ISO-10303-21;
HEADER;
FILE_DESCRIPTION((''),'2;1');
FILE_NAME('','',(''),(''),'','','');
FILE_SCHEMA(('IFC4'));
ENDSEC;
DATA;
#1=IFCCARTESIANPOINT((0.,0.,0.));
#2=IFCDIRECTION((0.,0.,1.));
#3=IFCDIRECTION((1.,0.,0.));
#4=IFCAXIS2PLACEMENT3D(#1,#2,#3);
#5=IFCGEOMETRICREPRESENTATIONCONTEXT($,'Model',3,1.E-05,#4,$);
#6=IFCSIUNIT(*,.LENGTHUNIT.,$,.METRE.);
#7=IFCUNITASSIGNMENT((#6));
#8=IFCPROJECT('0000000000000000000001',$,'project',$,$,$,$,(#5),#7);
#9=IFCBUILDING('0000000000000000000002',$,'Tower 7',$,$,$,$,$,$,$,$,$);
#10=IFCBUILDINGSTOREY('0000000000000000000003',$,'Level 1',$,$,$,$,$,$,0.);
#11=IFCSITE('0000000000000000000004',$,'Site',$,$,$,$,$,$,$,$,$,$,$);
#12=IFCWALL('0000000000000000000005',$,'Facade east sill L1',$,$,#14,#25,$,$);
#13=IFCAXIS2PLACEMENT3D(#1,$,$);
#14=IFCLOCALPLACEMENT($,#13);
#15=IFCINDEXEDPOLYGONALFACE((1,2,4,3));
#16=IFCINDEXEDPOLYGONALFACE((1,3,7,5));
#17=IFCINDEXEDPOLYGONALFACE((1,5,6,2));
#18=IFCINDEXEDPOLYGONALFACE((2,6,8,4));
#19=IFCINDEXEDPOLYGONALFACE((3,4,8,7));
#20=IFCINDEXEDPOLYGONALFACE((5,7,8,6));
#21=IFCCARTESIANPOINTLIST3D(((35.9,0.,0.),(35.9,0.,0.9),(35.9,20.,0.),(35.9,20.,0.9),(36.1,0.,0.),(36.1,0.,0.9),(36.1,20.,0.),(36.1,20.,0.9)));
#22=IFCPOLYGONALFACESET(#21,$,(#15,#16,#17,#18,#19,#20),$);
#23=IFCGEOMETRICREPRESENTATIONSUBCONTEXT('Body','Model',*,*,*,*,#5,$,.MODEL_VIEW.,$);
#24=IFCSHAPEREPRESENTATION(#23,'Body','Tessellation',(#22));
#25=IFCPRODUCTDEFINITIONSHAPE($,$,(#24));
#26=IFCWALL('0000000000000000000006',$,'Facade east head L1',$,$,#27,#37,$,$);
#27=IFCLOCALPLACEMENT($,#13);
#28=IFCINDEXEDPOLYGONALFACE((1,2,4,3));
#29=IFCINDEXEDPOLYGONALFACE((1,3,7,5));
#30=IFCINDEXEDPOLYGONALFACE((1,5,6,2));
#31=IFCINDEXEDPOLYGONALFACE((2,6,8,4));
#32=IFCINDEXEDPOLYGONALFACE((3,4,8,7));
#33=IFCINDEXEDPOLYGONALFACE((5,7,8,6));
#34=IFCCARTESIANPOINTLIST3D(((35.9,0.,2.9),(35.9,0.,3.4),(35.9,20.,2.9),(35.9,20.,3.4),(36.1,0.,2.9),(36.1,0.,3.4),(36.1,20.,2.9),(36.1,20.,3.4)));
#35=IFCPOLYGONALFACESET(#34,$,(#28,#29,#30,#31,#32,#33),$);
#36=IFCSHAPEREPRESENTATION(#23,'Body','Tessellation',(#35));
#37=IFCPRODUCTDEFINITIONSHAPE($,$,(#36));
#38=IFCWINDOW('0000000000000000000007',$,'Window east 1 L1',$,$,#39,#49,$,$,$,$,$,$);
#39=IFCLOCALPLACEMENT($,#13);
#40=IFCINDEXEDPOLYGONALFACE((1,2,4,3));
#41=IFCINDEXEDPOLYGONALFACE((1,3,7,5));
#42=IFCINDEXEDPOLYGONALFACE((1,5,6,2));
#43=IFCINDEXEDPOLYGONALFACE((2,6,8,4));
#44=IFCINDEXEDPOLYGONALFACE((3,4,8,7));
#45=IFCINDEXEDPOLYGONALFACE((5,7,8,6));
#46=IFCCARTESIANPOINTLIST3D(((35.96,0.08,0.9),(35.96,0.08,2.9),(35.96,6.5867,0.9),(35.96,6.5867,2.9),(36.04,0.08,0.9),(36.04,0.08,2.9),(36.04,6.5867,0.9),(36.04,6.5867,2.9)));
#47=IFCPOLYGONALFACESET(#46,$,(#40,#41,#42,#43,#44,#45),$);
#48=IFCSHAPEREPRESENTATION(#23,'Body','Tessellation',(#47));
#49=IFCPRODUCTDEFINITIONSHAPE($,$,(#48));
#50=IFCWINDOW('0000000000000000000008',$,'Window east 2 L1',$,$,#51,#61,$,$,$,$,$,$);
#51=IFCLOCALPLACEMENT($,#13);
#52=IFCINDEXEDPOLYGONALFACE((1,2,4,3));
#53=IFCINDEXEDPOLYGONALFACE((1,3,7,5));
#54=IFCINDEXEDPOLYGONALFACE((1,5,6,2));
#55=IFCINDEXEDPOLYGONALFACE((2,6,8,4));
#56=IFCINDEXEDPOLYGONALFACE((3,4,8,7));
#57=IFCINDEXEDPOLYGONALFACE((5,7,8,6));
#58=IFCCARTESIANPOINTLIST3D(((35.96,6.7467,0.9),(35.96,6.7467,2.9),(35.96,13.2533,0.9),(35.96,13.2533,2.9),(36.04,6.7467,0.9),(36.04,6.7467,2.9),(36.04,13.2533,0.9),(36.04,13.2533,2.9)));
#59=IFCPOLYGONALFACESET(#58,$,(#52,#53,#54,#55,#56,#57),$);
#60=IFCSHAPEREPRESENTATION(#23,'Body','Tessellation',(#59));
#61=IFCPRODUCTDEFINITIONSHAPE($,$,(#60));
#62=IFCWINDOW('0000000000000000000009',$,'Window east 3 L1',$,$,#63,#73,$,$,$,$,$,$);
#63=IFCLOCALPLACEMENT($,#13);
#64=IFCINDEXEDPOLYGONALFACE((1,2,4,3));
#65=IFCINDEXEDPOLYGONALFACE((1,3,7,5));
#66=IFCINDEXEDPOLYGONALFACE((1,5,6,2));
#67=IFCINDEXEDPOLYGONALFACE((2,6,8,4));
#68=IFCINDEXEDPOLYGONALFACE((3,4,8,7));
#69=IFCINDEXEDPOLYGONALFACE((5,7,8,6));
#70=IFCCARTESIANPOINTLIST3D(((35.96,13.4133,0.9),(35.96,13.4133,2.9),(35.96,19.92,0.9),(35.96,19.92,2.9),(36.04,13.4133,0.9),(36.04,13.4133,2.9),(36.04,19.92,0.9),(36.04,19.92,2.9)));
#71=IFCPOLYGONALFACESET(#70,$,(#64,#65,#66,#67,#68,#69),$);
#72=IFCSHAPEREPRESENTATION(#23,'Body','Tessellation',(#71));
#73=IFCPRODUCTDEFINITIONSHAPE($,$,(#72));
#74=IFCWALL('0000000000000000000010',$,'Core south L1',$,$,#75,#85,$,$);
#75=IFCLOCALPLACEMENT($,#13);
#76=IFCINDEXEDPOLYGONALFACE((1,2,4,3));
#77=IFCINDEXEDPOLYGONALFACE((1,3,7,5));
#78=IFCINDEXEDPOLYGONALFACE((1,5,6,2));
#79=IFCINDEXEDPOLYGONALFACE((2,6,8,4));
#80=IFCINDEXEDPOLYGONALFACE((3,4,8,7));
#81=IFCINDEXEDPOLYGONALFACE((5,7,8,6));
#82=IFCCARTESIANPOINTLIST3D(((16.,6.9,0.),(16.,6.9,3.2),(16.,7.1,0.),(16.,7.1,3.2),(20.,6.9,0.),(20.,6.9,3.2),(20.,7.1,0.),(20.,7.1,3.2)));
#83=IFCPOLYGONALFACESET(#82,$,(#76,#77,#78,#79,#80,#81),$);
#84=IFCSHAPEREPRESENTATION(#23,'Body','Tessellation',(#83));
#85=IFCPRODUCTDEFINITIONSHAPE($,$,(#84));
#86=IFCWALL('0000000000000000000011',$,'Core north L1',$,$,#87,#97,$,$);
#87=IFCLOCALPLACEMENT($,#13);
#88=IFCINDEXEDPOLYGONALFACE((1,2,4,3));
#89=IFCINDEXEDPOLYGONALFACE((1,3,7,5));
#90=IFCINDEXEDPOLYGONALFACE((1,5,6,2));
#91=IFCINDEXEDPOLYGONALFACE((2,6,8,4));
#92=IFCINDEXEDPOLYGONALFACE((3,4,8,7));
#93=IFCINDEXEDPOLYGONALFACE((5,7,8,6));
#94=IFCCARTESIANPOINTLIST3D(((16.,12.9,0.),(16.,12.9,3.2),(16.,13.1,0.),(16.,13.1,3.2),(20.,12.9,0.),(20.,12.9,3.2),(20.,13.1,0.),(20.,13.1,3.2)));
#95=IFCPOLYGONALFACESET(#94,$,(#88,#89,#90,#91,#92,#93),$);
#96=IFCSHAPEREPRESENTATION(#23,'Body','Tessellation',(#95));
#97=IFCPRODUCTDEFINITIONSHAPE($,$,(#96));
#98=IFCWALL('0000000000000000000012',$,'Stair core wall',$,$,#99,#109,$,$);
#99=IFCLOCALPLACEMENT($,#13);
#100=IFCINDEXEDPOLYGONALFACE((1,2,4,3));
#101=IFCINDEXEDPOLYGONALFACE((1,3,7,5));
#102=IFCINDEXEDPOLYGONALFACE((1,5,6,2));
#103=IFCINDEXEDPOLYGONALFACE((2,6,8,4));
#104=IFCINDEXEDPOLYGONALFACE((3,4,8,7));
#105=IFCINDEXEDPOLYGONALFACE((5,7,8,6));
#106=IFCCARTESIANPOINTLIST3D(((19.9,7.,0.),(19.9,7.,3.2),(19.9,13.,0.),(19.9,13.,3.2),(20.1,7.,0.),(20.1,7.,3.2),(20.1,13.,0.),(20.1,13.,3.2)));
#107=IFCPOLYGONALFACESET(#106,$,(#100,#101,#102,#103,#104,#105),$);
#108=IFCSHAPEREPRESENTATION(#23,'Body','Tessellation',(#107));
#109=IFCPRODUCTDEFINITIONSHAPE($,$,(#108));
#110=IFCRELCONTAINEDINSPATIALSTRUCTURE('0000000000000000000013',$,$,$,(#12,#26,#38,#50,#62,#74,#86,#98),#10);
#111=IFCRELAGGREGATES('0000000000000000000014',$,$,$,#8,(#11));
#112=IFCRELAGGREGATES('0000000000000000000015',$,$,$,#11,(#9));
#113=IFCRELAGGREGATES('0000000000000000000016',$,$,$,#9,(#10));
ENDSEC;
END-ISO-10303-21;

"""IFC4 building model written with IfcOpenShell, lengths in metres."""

from ifc_helpers import new_model, si_unit, frame, origin, origin_with_axes, origin_2d, place, context, subcontext, project, spatial, rectangle, extrude, element, save


model = new_model("IFC4")

# Units and contexts
model_context = context("Model", 3, precision=1e-05, world=origin_with_axes())
body_context = subcontext(model_context, "Body", "Model", "MODEL_VIEW")
ifc_project = project(units=[si_unit("LENGTHUNIT", "METRE")], contexts=[model_context])

# Site, building, storey
site = spatial("IfcSite", under=ifc_project, Name="Site")
building = spatial("IfcBuilding", under=site, Name="Tower 7")
storey = spatial("IfcBuildingStorey", under=building, Name="Level 1", Elevation=0.0)

# Walls
wall_1_placement = place(None, frame((36.0, 10.0, 0.0), z_axis=(0.0, 0.0, 1.0), x_axis=(1.0, 0.0, 0.0)))
element("IfcWall", 1, at=wall_1_placement, inside=storey, Name="Facade east sill L1", context=body_context, shape_type="SweptSolid", body=[
    extrude(rectangle(XDim=0.2, YDim=20.0, at=origin_2d()), origin(), (0.0, 0.0, 1.0), 0.9),
])
wall_2_placement = place(None, frame((36.0, 10.0, 2.9), z_axis=(0.0, 0.0, 1.0), x_axis=(1.0, 0.0, 0.0)))
element("IfcWall", 2, at=wall_2_placement, inside=storey, Name="Facade east head L1", context=body_context, shape_type="SweptSolid", body=[
    extrude(rectangle(XDim=0.2, YDim=20.0, at=origin_2d()), origin(), (0.0, 0.0, 1.0), 0.5),
])

# Windows
for number, where, z_axis, x_axis, name in (
    (3, (36.0, 3.3333, 0.9), (0.0, 0.0, 1.0), (1.0, 0.0, 0.0), "Window east 1 L1"),
    (4, (36.0, 10.0, 0.9), (0.0, 0.0, 1.0), (1.0, 0.0, 0.0), "Window east 2 L1"),
):
    element("IfcWindow", number, at=place(None, frame(where, z_axis=z_axis, x_axis=x_axis)), inside=storey, Name=name, context=body_context, shape_type="SweptSolid", body=[
        extrude(rectangle(XDim=0.08, YDim=6.5067, at=origin_2d()), origin(), (0.0, 0.0, 1.0), 2.0),
    ])
window_placement = place(None, frame((36.0, 16.6667, 0.9), z_axis=(0.0, 0.0, 1.0), x_axis=(1.0, 0.0, 0.0)))
element("IfcWindow", 5, at=window_placement, inside=storey, Name="Window east 3 L1", context=body_context, shape_type="SweptSolid", body=[
    extrude(rectangle(XDim=0.08, YDim=6.5067, at=origin_2d()), origin(), (0.0, 0.0, 1.0), 2.0),
])

# Walls
for number, where, z_axis, x_axis, name in (
    (6, (18.0, 7.0, 0.0), (0.0, 0.0, 1.0), (1.0, 0.0, 0.0), "Core south L1"),
    (7, (18.0, 13.0, 0.0), (0.0, 0.0, 1.0), (1.0, 0.0, 0.0), "Core north L1"),
):
    element("IfcWall", number, at=place(None, frame(where, z_axis=z_axis, x_axis=x_axis)), inside=storey, Name=name, context=body_context, shape_type="SweptSolid", body=[
        extrude(rectangle(XDim=4.0, YDim=0.2, at=origin_2d()), origin(), (0.0, 0.0, 1.0), 3.2),
    ])
wall_3_placement = place(None, frame((20.0, 10.0, 0.0), z_axis=(0.0, 0.0, 1.0), x_axis=(1.0, 0.0, 0.0)))
element("IfcWall", 8, at=wall_3_placement, inside=storey, Name="Stair core wall", context=body_context, shape_type="SweptSolid", body=[
    extrude(rectangle(XDim=0.2, YDim=6.0, at=origin_2d()), origin(), (0.0, 0.0, 1.0), 3.2),
])

save(model, "model.ifc")
